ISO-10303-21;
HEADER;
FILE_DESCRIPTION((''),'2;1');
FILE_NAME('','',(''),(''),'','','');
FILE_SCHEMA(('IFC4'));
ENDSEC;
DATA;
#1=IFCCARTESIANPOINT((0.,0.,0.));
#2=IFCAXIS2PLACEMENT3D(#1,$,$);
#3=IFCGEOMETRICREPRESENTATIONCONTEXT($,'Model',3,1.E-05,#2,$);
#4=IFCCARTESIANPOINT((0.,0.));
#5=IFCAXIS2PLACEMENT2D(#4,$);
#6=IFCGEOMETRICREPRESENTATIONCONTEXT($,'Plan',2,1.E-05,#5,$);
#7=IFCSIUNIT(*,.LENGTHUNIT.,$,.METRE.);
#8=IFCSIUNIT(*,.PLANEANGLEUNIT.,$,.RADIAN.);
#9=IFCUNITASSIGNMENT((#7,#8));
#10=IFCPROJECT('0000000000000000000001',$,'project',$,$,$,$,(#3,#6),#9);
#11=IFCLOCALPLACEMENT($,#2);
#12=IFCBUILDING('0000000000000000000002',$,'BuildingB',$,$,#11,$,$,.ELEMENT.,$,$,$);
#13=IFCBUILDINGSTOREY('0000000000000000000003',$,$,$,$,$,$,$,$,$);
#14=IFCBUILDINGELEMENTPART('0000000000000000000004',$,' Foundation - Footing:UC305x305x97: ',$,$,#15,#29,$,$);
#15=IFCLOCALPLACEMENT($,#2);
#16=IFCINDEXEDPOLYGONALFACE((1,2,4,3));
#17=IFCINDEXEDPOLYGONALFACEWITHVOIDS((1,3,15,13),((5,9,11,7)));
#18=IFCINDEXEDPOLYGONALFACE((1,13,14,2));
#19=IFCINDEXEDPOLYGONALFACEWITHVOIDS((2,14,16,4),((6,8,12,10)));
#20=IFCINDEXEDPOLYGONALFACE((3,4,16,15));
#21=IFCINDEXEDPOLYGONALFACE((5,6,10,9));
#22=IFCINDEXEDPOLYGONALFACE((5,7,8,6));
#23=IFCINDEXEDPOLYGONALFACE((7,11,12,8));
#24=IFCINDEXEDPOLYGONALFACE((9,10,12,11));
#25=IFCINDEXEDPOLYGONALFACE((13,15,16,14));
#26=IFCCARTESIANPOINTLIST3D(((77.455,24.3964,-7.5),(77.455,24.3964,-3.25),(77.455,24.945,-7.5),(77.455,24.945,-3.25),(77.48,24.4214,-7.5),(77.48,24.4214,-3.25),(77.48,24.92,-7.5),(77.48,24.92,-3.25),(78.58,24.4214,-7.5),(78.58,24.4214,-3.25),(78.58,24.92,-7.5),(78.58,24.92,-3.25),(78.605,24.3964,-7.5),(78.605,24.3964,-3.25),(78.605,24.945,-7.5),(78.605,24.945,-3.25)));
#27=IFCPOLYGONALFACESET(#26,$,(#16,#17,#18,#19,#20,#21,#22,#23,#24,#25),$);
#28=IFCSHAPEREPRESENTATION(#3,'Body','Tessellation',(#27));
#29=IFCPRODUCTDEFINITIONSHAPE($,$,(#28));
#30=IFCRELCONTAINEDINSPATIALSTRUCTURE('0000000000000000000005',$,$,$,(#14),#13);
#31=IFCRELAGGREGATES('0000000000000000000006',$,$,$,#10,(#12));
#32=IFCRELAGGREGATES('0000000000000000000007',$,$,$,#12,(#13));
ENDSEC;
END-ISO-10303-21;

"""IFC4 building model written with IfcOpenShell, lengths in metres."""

from ifc_helpers import new_model, si_unit, origin, origin_2d, place, context, project, spatial, polyline, outline, extrude, element, save


model = new_model("IFC4")

# Units and contexts
model_context = context("Model", 3, precision=1e-05, world=origin())
plan_context = context("Plan", 2, precision=1e-05, world=origin_2d())
ifc_project = project(units=[si_unit("LENGTHUNIT", "METRE"), si_unit("PLANEANGLEUNIT", "RADIAN")], contexts=[model_context, plan_context])

# Building, storey
building_placement = place(None, origin())
building = spatial("IfcBuilding", under=ifc_project, at=building_placement, Name="BuildingB", CompositionType="ELEMENT")
storey = spatial("IfcBuildingStorey", under=building)

# Building element part, opening
building_element_part_1 = element("IfcBuildingElementPart", 1, inside=storey, Name=" Foundation - Footing:UC305x305x97: ", context=model_context, shape_type="SweptSolid", body=[
    extrude(outline(polyline([(77.455, 24.3964, -7.5), (78.605, 24.3964, -7.5), (78.605, 24.945, -7.5), (77.455, 24.945, -7.5), (77.455, 24.3964, -7.5)])), None, (0.0, 0.0, 1.0), 4.25),
])
element("IfcOpeningElement", 2, inside=storey, cuts=building_element_part_1, context=model_context, shape_type="SweptSolid", body=[
    extrude(outline(polyline([(77.48, 24.4214, -7.5), (78.58, 24.4214, -7.5), (78.58, 24.92, -7.5), (77.48, 24.92, -7.5), (77.48, 24.4214, -7.5)])), None, (0.0, 0.0, 1.0), 4.25),
])

save(model, "model.ifc")
